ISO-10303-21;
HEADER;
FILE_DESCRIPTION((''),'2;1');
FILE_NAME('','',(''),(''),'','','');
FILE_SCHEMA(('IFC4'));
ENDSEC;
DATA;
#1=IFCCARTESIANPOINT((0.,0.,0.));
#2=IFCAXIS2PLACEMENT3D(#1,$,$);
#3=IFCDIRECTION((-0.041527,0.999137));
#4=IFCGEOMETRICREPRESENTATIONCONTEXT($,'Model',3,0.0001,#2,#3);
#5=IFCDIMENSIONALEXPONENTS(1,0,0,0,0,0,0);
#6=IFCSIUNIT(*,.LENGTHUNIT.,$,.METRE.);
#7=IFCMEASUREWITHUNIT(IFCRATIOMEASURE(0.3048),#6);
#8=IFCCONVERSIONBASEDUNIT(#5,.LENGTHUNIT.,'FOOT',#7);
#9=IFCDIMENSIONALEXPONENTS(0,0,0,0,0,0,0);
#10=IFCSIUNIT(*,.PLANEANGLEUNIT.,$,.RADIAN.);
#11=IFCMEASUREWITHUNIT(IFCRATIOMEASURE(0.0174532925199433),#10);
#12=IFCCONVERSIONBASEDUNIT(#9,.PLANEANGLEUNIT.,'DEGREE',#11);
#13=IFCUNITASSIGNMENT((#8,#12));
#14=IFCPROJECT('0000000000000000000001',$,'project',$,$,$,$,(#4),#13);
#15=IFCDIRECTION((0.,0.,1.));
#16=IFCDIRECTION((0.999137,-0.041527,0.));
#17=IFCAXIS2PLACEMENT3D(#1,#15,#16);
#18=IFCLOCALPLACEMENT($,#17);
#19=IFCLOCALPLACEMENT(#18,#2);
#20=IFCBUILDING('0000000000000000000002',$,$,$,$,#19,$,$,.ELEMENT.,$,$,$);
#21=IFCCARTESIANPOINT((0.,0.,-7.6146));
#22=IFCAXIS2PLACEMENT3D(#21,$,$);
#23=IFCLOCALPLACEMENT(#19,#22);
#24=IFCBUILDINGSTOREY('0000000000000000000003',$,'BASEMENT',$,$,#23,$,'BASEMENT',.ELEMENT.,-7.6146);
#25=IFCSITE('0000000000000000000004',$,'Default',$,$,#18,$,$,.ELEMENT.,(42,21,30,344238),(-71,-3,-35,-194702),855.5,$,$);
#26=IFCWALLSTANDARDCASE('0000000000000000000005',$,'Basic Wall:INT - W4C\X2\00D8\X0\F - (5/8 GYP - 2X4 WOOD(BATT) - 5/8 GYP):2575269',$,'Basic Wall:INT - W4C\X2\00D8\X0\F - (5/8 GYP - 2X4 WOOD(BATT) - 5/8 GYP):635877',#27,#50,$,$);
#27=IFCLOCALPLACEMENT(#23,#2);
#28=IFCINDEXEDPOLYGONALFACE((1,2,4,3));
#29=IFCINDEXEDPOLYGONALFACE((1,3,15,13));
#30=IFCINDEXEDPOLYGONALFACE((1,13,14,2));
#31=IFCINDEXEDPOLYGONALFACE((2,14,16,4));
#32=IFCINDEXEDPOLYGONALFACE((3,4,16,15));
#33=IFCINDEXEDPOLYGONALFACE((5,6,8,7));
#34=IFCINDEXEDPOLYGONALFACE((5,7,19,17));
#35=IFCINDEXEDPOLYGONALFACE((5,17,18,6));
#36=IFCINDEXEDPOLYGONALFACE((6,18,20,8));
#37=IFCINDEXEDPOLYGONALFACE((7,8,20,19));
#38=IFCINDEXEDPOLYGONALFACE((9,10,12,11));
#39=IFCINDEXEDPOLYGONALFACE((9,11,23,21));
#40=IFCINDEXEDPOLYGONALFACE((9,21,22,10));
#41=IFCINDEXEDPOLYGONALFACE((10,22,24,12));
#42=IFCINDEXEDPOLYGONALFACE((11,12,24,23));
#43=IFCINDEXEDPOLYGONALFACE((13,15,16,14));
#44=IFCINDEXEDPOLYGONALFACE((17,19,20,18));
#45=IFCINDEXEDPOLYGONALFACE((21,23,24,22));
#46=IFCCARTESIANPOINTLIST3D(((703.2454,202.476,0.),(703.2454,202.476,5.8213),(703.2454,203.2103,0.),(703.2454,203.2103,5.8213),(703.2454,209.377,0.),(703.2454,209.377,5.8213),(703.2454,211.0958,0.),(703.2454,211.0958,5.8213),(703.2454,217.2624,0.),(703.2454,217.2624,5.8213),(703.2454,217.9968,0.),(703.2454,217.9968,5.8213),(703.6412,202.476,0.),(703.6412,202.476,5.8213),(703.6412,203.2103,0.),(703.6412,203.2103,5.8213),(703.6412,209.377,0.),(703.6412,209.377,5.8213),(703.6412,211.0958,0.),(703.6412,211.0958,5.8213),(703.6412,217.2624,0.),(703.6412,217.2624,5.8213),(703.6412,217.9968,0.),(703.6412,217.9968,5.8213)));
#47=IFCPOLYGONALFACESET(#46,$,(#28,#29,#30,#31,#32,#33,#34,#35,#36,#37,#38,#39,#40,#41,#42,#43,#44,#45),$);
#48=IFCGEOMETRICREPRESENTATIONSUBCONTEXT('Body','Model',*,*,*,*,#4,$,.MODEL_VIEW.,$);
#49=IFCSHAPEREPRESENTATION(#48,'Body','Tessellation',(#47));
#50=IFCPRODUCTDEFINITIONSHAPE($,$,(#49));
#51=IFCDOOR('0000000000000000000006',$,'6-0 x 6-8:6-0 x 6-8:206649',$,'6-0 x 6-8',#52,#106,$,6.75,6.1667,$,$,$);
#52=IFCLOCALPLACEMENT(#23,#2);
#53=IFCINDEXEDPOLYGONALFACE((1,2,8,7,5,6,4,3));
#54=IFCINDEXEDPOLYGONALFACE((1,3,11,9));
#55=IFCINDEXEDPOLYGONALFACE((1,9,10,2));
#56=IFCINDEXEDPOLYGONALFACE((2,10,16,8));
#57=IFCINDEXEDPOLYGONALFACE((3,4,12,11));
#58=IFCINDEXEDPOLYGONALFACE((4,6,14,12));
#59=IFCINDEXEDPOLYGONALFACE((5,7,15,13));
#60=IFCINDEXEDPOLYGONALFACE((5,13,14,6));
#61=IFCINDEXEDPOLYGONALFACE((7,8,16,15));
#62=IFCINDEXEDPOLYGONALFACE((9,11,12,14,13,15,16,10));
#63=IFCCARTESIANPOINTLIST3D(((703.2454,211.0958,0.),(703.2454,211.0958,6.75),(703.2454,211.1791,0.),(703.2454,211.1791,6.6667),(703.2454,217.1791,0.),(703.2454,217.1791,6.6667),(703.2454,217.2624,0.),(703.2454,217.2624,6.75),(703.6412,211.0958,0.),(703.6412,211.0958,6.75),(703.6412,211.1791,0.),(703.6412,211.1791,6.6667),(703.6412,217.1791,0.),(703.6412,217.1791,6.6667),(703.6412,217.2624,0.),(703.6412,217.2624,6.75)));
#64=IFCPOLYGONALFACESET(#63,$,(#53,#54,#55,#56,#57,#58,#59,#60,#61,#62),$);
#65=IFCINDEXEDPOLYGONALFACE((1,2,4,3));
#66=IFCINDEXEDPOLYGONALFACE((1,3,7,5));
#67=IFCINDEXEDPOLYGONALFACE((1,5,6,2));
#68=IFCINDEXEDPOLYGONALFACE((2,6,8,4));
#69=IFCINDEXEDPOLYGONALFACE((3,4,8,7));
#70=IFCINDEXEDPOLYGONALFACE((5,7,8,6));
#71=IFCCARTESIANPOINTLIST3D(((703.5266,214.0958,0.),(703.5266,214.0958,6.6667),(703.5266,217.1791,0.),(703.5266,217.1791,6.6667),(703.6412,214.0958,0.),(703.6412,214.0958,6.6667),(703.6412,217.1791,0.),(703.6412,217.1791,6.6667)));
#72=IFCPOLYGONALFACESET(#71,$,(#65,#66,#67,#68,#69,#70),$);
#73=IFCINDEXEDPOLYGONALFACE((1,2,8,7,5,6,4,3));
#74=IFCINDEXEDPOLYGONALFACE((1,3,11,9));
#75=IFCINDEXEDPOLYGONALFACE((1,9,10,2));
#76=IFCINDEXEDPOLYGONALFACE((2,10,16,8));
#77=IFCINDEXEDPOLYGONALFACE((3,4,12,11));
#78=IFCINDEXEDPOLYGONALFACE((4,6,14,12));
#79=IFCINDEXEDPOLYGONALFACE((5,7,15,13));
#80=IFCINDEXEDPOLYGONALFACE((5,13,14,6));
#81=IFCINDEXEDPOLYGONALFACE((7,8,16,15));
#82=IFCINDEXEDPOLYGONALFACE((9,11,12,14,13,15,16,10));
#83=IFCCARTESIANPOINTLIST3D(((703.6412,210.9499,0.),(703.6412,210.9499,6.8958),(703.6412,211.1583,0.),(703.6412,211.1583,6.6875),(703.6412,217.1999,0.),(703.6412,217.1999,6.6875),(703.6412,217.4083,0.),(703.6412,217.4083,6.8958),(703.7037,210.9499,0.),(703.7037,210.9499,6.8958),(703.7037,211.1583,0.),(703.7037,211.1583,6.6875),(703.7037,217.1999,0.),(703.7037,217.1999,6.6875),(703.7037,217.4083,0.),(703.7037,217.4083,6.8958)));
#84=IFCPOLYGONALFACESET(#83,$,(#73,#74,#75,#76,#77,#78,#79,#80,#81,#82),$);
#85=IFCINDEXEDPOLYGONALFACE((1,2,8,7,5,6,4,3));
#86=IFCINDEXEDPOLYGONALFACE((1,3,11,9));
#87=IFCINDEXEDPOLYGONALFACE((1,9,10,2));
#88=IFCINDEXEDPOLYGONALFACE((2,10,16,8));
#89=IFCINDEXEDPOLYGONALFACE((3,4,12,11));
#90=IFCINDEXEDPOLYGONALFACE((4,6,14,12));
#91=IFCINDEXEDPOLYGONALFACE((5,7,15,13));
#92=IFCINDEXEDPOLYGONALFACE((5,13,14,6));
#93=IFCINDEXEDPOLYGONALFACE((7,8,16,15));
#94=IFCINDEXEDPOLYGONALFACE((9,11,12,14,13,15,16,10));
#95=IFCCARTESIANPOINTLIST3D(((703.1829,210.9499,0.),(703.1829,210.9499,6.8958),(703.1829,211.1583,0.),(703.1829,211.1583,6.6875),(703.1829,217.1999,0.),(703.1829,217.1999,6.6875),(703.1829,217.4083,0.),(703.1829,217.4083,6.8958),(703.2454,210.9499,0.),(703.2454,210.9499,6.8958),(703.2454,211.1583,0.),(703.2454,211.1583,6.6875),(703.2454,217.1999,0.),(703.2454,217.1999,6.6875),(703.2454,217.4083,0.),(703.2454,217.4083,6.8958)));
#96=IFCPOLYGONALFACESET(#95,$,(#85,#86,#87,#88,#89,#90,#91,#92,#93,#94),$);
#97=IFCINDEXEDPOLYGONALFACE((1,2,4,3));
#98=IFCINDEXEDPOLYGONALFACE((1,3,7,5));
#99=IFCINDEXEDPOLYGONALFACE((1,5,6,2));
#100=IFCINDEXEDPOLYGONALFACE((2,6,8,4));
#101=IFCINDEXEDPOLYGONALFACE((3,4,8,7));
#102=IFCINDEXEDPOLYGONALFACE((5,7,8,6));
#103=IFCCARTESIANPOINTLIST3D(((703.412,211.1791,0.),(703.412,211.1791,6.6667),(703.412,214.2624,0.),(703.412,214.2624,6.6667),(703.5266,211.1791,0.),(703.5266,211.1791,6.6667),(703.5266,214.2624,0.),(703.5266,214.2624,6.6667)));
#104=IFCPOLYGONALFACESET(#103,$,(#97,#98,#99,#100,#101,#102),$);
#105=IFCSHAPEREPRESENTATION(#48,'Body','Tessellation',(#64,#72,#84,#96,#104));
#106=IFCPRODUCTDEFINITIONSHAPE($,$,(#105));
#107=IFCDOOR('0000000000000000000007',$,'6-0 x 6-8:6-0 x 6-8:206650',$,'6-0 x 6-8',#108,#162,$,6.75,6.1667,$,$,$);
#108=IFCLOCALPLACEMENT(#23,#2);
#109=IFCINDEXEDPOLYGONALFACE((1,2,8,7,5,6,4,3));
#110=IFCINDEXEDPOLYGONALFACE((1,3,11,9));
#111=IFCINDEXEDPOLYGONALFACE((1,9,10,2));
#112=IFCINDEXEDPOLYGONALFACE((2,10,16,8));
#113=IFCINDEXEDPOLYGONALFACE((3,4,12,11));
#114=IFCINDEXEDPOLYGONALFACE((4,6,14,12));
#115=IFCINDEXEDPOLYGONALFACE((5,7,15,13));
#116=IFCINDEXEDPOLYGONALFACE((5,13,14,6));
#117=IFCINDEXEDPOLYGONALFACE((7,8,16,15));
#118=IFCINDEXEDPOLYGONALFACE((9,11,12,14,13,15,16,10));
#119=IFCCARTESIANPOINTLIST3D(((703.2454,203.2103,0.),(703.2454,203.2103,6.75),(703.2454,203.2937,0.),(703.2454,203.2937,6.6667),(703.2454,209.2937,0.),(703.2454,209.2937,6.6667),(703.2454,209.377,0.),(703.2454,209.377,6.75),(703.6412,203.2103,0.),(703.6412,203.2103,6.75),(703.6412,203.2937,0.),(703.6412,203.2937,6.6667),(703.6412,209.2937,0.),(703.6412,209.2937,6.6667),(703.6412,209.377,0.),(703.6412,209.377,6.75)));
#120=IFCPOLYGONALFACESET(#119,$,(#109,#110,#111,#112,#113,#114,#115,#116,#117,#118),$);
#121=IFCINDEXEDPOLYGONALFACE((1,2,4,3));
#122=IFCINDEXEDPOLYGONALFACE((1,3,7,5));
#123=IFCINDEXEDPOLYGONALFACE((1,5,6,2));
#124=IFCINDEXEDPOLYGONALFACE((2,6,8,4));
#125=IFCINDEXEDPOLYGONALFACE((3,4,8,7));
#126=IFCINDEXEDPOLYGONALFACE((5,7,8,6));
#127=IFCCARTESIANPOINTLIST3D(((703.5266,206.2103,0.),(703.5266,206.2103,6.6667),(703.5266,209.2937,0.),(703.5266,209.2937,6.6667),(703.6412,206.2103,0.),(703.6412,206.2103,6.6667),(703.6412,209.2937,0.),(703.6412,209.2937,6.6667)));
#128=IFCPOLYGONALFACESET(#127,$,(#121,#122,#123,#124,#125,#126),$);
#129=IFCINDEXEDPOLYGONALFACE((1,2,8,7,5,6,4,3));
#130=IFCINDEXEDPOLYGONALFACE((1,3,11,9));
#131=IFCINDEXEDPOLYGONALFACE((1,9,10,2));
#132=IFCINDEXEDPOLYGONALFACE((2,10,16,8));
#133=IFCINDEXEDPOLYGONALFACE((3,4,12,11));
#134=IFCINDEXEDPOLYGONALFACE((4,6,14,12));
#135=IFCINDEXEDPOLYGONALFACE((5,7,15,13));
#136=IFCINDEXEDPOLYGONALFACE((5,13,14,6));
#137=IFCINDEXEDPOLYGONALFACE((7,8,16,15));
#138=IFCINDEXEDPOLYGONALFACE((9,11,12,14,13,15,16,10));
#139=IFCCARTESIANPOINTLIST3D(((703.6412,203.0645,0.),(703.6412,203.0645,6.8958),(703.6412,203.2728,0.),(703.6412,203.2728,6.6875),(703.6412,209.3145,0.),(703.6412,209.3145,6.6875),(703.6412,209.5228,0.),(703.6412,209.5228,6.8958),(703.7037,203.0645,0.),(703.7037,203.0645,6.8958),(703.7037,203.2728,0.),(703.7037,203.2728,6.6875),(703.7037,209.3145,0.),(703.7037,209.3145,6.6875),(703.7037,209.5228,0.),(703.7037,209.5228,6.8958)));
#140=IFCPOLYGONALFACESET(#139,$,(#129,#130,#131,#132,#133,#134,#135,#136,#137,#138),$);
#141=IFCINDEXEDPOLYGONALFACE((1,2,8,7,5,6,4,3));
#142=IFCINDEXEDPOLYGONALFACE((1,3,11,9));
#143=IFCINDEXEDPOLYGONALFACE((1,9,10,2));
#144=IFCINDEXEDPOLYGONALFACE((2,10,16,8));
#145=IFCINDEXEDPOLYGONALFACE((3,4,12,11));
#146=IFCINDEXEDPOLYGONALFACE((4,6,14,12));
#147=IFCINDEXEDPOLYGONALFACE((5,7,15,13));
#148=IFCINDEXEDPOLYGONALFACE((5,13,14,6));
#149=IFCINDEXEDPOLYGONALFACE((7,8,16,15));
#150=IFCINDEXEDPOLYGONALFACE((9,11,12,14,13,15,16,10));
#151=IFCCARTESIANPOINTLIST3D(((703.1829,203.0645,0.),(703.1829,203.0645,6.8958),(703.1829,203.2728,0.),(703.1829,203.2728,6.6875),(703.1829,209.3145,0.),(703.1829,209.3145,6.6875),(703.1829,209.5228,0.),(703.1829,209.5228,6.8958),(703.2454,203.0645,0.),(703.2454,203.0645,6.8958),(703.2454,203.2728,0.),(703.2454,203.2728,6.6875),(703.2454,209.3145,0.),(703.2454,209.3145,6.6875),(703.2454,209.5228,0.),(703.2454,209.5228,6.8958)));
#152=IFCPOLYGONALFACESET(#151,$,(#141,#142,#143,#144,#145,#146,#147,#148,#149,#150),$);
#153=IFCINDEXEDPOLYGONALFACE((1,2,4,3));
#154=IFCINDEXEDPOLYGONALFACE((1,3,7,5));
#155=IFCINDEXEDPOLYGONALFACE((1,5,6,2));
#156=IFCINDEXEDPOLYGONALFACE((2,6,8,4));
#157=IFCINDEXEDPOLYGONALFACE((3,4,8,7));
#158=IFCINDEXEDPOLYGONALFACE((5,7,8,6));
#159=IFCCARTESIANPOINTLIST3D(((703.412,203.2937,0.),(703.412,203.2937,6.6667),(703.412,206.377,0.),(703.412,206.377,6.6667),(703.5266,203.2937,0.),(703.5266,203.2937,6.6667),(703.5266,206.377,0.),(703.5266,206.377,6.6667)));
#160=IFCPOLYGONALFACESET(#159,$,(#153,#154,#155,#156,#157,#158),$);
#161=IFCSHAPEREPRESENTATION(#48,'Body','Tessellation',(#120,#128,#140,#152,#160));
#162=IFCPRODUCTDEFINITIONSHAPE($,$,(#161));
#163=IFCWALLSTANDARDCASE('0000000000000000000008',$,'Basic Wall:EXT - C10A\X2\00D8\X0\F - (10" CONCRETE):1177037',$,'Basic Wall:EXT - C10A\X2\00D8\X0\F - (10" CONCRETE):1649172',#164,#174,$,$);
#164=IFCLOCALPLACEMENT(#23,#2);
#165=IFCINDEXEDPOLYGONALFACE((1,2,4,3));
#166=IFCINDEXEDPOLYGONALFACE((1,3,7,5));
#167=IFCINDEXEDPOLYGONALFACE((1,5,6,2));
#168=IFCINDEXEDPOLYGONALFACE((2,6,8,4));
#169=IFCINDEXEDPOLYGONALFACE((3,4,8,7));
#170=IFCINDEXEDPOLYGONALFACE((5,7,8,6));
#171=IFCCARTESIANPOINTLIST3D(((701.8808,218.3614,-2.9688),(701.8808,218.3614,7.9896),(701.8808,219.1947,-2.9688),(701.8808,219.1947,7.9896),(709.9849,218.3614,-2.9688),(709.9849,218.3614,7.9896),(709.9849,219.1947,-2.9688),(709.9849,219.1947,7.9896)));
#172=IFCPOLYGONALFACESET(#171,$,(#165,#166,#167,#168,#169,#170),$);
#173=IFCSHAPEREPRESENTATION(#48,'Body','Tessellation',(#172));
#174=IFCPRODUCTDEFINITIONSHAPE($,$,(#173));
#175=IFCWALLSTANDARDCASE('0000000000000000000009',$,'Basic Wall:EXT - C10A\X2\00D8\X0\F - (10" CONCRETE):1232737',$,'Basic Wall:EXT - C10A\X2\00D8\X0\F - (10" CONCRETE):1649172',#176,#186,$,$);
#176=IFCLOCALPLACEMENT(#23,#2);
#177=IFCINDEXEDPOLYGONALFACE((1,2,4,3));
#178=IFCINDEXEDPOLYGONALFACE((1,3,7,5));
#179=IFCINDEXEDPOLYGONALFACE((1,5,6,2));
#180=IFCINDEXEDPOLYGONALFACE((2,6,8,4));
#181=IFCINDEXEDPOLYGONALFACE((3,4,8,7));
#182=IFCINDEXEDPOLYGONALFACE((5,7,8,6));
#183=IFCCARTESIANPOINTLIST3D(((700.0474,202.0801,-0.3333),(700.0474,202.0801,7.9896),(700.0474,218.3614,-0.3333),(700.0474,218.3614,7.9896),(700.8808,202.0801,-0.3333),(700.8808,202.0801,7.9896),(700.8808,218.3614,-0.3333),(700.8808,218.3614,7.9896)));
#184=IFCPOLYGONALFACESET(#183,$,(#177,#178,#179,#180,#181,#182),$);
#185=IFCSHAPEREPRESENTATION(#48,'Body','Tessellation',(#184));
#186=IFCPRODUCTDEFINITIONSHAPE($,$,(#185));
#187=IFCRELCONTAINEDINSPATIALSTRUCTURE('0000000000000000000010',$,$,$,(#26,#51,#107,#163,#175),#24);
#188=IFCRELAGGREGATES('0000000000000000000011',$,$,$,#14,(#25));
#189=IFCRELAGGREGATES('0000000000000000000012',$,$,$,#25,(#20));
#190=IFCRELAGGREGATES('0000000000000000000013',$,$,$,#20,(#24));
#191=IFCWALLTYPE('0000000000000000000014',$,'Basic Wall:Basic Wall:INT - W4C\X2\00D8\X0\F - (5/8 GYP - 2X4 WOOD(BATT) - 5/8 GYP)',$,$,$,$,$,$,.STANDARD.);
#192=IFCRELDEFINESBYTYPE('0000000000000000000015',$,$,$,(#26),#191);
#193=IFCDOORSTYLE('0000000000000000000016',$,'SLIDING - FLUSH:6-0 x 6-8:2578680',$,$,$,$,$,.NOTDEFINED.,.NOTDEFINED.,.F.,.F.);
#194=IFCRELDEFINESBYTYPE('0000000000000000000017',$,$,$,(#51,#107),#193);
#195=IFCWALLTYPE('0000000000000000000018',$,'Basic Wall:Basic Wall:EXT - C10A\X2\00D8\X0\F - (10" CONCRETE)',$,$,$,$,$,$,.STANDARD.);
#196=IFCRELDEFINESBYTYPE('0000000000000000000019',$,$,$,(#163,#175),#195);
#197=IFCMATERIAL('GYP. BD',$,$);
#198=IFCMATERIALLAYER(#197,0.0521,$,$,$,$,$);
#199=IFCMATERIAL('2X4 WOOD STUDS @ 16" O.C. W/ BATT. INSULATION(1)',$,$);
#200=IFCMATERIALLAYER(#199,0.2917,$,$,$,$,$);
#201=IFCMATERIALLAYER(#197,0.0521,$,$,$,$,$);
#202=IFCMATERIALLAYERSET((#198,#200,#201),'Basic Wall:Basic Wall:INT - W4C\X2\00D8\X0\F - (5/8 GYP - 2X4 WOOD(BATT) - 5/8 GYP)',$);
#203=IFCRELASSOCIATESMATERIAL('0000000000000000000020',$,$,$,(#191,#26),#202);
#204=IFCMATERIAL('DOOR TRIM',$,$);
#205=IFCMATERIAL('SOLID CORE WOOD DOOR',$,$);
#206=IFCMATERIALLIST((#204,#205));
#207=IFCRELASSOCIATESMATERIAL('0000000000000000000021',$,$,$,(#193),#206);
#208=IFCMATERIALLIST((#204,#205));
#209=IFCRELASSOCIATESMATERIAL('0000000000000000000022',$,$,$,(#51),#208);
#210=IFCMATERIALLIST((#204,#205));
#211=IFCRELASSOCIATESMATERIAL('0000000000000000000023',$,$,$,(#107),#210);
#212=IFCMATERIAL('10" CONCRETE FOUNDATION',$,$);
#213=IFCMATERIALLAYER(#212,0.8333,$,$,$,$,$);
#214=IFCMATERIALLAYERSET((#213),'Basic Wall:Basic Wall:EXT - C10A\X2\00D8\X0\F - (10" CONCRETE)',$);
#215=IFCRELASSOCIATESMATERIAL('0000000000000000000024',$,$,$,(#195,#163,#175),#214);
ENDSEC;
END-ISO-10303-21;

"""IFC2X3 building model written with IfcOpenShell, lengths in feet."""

from ifc_helpers import new_model, entity, si_unit, converted_unit, direction, frame, frame_2d, origin, origin_2d_with_axis, place, context, subcontext, project, spatial, polyline, rectangle, outline, extrude, source, transform, mapped, material, material_list, layer, layer_set, layer_usage, type_object, type_shapes, element, fill, save


model = new_model("IFC2X3")

# Units and contexts
model_context = context("Model", 3, precision=0.0001, world=origin(), true_north=direction((-0.041527, 0.999137)))
body_context = subcontext(model_context, "Body", "Model", "MODEL_VIEW")
ifc_project = project(units=[converted_unit("LENGTHUNIT", "FOOT", entity("IfcRatioMeasure", 0.3048), si_unit("LENGTHUNIT", "METRE"), dimensions=[1, 0, 0, 0, 0, 0, 0]), converted_unit("PLANEANGLEUNIT", "DEGREE", entity("IfcRatioMeasure", 0.0174532925199433), si_unit("PLANEANGLEUNIT", "RADIAN"), dimensions=[0, 0, 0, 0, 0, 0, 0])], contexts=[model_context])

# Site, building, storey
site_placement = place(None, frame((0.0, 0.0, 0.0), z_axis=(0.0, 0.0, 1.0), x_axis=(0.999137, -0.041527, 0.0)))
site = spatial("IfcSite", under=ifc_project, at=site_placement, Name="Default", CompositionType="ELEMENT", RefLatitude=(42, 21, 30, 344238), RefLongitude=(-71, -3, -35, -194702), RefElevation=855.5)
building_placement = place(site_placement, origin())
building = spatial("IfcBuilding", under=site, at=building_placement, CompositionType="ELEMENT")
storey_placement = place(building_placement, frame((0.0, 0.0, -7.6146)))
storey = spatial("IfcBuildingStorey", under=building, at=storey_placement, Name="BASEMENT", LongName="BASEMENT", CompositionType="ELEMENT", Elevation=-7.6146)

# Shared definitions
ifc_material_1 = material(Name="GYP. BD")

# Shared definitions
ifc_layer_1 = layer(ifc_material_1, 0.0521)
ifc_material_2 = material(Name="2X4 WOOD STUDS @ 16\" O.C. W/ BATT. INSULATION(1)")
ifc_layer_2 = layer(ifc_material_2, 0.2917)
ifc_layer_3 = layer(ifc_material_1, 0.0521)
ifc_layer_set_1 = layer_set([ifc_layer_1, ifc_layer_2, ifc_layer_3], Name="Basic Wall:Basic Wall:INT - W4CØF - (5/8 GYP - 2X4 WOOD(BATT) - 5/8 GYP)")
wall_type_1 = type_object("IfcWallType", Name="Basic Wall:Basic Wall:INT - W4CØF - (5/8 GYP - 2X4 WOOD(BATT) - 5/8 GYP)", PredefinedType="STANDARD", material=ifc_layer_set_1)

# Wall, openings, doors
ifc_layer_usage_1 = layer_usage(ifc_layer_set_1, "AXIS2", "NEGATIVE", 0.1979)
wall_1_placement = place(storey_placement, frame((703.4433, 217.9968, 0.0), z_axis=(0.0, 0.0, 1.0), x_axis=(0.0, -1.0, 0.0)))
wall_1 = element("IfcWallStandardCase", 1, at=wall_1_placement, inside=storey, type_object=wall_type_1, material=ifc_layer_usage_1, Name="Basic Wall:INT - W4CØF - (5/8 GYP - 2X4 WOOD(BATT) - 5/8 GYP):2575269", ObjectType="Basic Wall:INT - W4CØF - (5/8 GYP - 2X4 WOOD(BATT) - 5/8 GYP):635877", context=body_context, shape_type="SweptSolid", body=[
    extrude(rectangle(XDim=15.5208, YDim=0.3958, at=frame_2d((7.7604, 0.0), x_axis=(-1.0, 0.0))), origin(), (0.0, 0.0, 1.0), 5.8213),
])
opening_1_placement = place(wall_1_placement, frame((217.9968, -703.4433, 0.0), z_axis=(0.0, 0.0, 1.0), x_axis=(0.0, 1.0, 0.0)))
opening_1 = element("IfcOpeningElement", 2, at=opening_1_placement, cuts=wall_1, ObjectType="Opening", context=body_context, shape_type="SweptSolid", body=[
    extrude(rectangle(XDim=6.75, YDim=6.1667, at=frame_2d((0.0, 0.0), x_axis=(0.0, 1.0))), frame((703.2414, 214.1791, 3.375), z_axis=(1.0, 0.0, 0.0), x_axis=(0.0, -1.0, 0.0)), (0.0, 0.0, 1.0), 0.4037),
])
opening_2_placement = place(wall_1_placement, frame((217.9968, -703.4433, 0.0), z_axis=(0.0, 0.0, 1.0), x_axis=(0.0, 1.0, 0.0)))
opening_2 = element("IfcOpeningElement", 3, at=opening_2_placement, cuts=wall_1, ObjectType="Opening", context=body_context, shape_type="SweptSolid", body=[
    extrude(rectangle(XDim=6.75, YDim=6.1667, at=frame_2d((0.0, 0.0), x_axis=(0.0, 1.0))), frame((703.2414, 206.2937, 3.375), z_axis=(1.0, 0.0, 0.0), x_axis=(0.0, -1.0, 0.0)), (0.0, 0.0, 1.0), 0.4037),
])
ifc_material_3 = material(Name="DOOR TRIM")
ifc_material_4 = material(Name="SOLID CORE WOOD DOOR")
ifc_material_list_1 = material_list([ifc_material_3, ifc_material_4])
ifc_material_list_2 = material_list([ifc_material_3, ifc_material_4])
door_style_1 = type_object("IfcDoorStyle", Name="SLIDING - FLUSH:6-0 x 6-8:2578680", ConstructionType="NOTDEFINED", OperationType="NOTDEFINED", ParameterTakesPrecedence=False, Sizeable=False, material=ifc_material_list_2)
shared_shape_1 = source(origin(), body_context, "Body", "SweptSolid", [
    extrude(outline(polyline([(-3.0, -3.3125), (-3.0, 3.3542), (-3.0833, 3.3542), (-3.0833, -3.3958), (3.0833, -3.3958), (3.0833, 3.3542), (3.0, 3.3542), (3.0, -3.3125), (-3.0, -3.3125)])), frame((3.0833, -0.3998, 3.3542), z_axis=(0.0, -1.0, 0.0), x_axis=(-1.0, 0.0, 0.0)), (0.0, 0.0, -1.0), 0.3958),
    extrude(rectangle(XDim=3.0833, YDim=0.1146, at=origin_2d_with_axis()), frame((1.625, -0.0612, 0.0), z_axis=(0.0, 0.0, 1.0), x_axis=(-1.0, 0.0, 0.0)), (0.0, 0.0, 1.0), 6.6667),
    extrude(outline(polyline([(-3.0208, -3.2917), (-3.0208, 3.3958), (-3.2292, 3.3958), (-3.2292, -3.5), (3.2292, -3.5), (3.2292, 3.3958), (3.0208, 3.3958), (3.0208, -3.2917), (-3.0208, -3.2917)])), frame((3.0833, -0.004, 3.3958), z_axis=(0.0, -1.0, 0.0), x_axis=(-1.0, 0.0, 0.0)), (0.0, 0.0, -1.0), 0.0625),
    extrude(outline(polyline([(-3.0208, -3.2917), (-3.0208, 3.3958), (-3.2292, 3.3958), (-3.2292, -3.5), (3.2292, -3.5), (3.2292, 3.3958), (3.0208, 3.3958), (3.0208, -3.2917), (-3.0208, -3.2917)])), frame((3.0833, -0.4623, 3.3958), z_axis=(0.0, -1.0, 0.0), x_axis=(-1.0, 0.0, 0.0)), (0.0, 0.0, -1.0), 0.0625),
    extrude(rectangle(XDim=3.0833, YDim=0.1146, at=origin_2d_with_axis()), frame((4.5417, -0.1758, 0.0), z_axis=(0.0, 0.0, 1.0), x_axis=(-1.0, 0.0, 0.0)), (0.0, 0.0, 1.0), 6.6667),
])
type_shapes(door_style_1, [shared_shape_1])
door_1_placement = place(opening_1_placement, frame((703.6452, 217.2624, 0.0), z_axis=(0.0, 0.0, 1.0), x_axis=(0.0, -1.0, 0.0)))
door_1 = element("IfcDoor", 4, at=door_1_placement, inside=storey, type_object=door_style_1, material=ifc_material_list_1, Name="6-0 x 6-8:6-0 x 6-8:206649", ObjectType="6-0 x 6-8", OverallHeight=6.75, OverallWidth=6.1667, context=body_context, shape_type="MappedRepresentation", body=[
    mapped(shared_shape_1, transform((0.0, 0.0, 0.0), scale=1.0)),
])
fill(opening_1, door_1)
ifc_material_list_3 = material_list([ifc_material_3, ifc_material_4])
door_2_placement = place(opening_2_placement, frame((703.6452, 209.377, 0.0), z_axis=(0.0, 0.0, 1.0), x_axis=(0.0, -1.0, 0.0)))
door_2 = element("IfcDoor", 5, at=door_2_placement, inside=storey, type_object=door_style_1, material=ifc_material_list_3, Name="6-0 x 6-8:6-0 x 6-8:206650", ObjectType="6-0 x 6-8", OverallHeight=6.75, OverallWidth=6.1667, context=body_context, shape_type="MappedRepresentation", body=[
    mapped(shared_shape_1, transform((0.0, 0.0, 0.0), scale=1.0)),
])
fill(opening_2, door_2)

# Shared definitions
ifc_material_5 = material(Name="10\" CONCRETE FOUNDATION")
ifc_layer_4 = layer(ifc_material_5, 0.8333)
ifc_layer_set_2 = layer_set([ifc_layer_4], Name="Basic Wall:Basic Wall:EXT - C10AØF - (10\" CONCRETE)")
wall_type_2 = type_object("IfcWallType", Name="Basic Wall:Basic Wall:EXT - C10AØF - (10\" CONCRETE)", PredefinedType="STANDARD", material=ifc_layer_set_2)

# Wall
ifc_layer_usage_2 = layer_usage(ifc_layer_set_2, "AXIS2", "NEGATIVE", 0.4167)
wall_2_placement = place(storey_placement, frame((701.8808, 218.7781, -2.9688)))
element("IfcWallStandardCase", 6, at=wall_2_placement, inside=storey, type_object=wall_type_2, material=ifc_layer_usage_2, Name="Basic Wall:EXT - C10AØF - (10\" CONCRETE):1177037", ObjectType="Basic Wall:EXT - C10AØF - (10\" CONCRETE):1649172", context=body_context, shape_type="SweptSolid", body=[
    extrude(rectangle(XDim=8.1042, YDim=0.8333, at=frame_2d((4.0521, 0.0), x_axis=(-1.0, 0.0))), origin(), (0.0, 0.0, 1.0), 10.9583),
])

# Wall
ifc_layer_usage_3 = layer_usage(ifc_layer_set_2, "AXIS2", "NEGATIVE", 0.4167)
wall_3_placement = place(storey_placement, frame((700.4641, 202.0801, -0.3333), z_axis=(0.0, 0.0, 1.0), x_axis=(0.0, 1.0, 0.0)))
element("IfcWallStandardCase", 7, at=wall_3_placement, inside=storey, type_object=wall_type_2, material=ifc_layer_usage_3, Name="Basic Wall:EXT - C10AØF - (10\" CONCRETE):1232737", ObjectType="Basic Wall:EXT - C10AØF - (10\" CONCRETE):1649172", context=body_context, shape_type="SweptSolid", body=[
    extrude(rectangle(XDim=16.2812, YDim=0.8333, at=frame_2d((8.1406, 0.0), x_axis=(-1.0, 0.0))), origin(), (0.0, 0.0, 1.0), 8.3229),
])

save(model, "model.ifc")
